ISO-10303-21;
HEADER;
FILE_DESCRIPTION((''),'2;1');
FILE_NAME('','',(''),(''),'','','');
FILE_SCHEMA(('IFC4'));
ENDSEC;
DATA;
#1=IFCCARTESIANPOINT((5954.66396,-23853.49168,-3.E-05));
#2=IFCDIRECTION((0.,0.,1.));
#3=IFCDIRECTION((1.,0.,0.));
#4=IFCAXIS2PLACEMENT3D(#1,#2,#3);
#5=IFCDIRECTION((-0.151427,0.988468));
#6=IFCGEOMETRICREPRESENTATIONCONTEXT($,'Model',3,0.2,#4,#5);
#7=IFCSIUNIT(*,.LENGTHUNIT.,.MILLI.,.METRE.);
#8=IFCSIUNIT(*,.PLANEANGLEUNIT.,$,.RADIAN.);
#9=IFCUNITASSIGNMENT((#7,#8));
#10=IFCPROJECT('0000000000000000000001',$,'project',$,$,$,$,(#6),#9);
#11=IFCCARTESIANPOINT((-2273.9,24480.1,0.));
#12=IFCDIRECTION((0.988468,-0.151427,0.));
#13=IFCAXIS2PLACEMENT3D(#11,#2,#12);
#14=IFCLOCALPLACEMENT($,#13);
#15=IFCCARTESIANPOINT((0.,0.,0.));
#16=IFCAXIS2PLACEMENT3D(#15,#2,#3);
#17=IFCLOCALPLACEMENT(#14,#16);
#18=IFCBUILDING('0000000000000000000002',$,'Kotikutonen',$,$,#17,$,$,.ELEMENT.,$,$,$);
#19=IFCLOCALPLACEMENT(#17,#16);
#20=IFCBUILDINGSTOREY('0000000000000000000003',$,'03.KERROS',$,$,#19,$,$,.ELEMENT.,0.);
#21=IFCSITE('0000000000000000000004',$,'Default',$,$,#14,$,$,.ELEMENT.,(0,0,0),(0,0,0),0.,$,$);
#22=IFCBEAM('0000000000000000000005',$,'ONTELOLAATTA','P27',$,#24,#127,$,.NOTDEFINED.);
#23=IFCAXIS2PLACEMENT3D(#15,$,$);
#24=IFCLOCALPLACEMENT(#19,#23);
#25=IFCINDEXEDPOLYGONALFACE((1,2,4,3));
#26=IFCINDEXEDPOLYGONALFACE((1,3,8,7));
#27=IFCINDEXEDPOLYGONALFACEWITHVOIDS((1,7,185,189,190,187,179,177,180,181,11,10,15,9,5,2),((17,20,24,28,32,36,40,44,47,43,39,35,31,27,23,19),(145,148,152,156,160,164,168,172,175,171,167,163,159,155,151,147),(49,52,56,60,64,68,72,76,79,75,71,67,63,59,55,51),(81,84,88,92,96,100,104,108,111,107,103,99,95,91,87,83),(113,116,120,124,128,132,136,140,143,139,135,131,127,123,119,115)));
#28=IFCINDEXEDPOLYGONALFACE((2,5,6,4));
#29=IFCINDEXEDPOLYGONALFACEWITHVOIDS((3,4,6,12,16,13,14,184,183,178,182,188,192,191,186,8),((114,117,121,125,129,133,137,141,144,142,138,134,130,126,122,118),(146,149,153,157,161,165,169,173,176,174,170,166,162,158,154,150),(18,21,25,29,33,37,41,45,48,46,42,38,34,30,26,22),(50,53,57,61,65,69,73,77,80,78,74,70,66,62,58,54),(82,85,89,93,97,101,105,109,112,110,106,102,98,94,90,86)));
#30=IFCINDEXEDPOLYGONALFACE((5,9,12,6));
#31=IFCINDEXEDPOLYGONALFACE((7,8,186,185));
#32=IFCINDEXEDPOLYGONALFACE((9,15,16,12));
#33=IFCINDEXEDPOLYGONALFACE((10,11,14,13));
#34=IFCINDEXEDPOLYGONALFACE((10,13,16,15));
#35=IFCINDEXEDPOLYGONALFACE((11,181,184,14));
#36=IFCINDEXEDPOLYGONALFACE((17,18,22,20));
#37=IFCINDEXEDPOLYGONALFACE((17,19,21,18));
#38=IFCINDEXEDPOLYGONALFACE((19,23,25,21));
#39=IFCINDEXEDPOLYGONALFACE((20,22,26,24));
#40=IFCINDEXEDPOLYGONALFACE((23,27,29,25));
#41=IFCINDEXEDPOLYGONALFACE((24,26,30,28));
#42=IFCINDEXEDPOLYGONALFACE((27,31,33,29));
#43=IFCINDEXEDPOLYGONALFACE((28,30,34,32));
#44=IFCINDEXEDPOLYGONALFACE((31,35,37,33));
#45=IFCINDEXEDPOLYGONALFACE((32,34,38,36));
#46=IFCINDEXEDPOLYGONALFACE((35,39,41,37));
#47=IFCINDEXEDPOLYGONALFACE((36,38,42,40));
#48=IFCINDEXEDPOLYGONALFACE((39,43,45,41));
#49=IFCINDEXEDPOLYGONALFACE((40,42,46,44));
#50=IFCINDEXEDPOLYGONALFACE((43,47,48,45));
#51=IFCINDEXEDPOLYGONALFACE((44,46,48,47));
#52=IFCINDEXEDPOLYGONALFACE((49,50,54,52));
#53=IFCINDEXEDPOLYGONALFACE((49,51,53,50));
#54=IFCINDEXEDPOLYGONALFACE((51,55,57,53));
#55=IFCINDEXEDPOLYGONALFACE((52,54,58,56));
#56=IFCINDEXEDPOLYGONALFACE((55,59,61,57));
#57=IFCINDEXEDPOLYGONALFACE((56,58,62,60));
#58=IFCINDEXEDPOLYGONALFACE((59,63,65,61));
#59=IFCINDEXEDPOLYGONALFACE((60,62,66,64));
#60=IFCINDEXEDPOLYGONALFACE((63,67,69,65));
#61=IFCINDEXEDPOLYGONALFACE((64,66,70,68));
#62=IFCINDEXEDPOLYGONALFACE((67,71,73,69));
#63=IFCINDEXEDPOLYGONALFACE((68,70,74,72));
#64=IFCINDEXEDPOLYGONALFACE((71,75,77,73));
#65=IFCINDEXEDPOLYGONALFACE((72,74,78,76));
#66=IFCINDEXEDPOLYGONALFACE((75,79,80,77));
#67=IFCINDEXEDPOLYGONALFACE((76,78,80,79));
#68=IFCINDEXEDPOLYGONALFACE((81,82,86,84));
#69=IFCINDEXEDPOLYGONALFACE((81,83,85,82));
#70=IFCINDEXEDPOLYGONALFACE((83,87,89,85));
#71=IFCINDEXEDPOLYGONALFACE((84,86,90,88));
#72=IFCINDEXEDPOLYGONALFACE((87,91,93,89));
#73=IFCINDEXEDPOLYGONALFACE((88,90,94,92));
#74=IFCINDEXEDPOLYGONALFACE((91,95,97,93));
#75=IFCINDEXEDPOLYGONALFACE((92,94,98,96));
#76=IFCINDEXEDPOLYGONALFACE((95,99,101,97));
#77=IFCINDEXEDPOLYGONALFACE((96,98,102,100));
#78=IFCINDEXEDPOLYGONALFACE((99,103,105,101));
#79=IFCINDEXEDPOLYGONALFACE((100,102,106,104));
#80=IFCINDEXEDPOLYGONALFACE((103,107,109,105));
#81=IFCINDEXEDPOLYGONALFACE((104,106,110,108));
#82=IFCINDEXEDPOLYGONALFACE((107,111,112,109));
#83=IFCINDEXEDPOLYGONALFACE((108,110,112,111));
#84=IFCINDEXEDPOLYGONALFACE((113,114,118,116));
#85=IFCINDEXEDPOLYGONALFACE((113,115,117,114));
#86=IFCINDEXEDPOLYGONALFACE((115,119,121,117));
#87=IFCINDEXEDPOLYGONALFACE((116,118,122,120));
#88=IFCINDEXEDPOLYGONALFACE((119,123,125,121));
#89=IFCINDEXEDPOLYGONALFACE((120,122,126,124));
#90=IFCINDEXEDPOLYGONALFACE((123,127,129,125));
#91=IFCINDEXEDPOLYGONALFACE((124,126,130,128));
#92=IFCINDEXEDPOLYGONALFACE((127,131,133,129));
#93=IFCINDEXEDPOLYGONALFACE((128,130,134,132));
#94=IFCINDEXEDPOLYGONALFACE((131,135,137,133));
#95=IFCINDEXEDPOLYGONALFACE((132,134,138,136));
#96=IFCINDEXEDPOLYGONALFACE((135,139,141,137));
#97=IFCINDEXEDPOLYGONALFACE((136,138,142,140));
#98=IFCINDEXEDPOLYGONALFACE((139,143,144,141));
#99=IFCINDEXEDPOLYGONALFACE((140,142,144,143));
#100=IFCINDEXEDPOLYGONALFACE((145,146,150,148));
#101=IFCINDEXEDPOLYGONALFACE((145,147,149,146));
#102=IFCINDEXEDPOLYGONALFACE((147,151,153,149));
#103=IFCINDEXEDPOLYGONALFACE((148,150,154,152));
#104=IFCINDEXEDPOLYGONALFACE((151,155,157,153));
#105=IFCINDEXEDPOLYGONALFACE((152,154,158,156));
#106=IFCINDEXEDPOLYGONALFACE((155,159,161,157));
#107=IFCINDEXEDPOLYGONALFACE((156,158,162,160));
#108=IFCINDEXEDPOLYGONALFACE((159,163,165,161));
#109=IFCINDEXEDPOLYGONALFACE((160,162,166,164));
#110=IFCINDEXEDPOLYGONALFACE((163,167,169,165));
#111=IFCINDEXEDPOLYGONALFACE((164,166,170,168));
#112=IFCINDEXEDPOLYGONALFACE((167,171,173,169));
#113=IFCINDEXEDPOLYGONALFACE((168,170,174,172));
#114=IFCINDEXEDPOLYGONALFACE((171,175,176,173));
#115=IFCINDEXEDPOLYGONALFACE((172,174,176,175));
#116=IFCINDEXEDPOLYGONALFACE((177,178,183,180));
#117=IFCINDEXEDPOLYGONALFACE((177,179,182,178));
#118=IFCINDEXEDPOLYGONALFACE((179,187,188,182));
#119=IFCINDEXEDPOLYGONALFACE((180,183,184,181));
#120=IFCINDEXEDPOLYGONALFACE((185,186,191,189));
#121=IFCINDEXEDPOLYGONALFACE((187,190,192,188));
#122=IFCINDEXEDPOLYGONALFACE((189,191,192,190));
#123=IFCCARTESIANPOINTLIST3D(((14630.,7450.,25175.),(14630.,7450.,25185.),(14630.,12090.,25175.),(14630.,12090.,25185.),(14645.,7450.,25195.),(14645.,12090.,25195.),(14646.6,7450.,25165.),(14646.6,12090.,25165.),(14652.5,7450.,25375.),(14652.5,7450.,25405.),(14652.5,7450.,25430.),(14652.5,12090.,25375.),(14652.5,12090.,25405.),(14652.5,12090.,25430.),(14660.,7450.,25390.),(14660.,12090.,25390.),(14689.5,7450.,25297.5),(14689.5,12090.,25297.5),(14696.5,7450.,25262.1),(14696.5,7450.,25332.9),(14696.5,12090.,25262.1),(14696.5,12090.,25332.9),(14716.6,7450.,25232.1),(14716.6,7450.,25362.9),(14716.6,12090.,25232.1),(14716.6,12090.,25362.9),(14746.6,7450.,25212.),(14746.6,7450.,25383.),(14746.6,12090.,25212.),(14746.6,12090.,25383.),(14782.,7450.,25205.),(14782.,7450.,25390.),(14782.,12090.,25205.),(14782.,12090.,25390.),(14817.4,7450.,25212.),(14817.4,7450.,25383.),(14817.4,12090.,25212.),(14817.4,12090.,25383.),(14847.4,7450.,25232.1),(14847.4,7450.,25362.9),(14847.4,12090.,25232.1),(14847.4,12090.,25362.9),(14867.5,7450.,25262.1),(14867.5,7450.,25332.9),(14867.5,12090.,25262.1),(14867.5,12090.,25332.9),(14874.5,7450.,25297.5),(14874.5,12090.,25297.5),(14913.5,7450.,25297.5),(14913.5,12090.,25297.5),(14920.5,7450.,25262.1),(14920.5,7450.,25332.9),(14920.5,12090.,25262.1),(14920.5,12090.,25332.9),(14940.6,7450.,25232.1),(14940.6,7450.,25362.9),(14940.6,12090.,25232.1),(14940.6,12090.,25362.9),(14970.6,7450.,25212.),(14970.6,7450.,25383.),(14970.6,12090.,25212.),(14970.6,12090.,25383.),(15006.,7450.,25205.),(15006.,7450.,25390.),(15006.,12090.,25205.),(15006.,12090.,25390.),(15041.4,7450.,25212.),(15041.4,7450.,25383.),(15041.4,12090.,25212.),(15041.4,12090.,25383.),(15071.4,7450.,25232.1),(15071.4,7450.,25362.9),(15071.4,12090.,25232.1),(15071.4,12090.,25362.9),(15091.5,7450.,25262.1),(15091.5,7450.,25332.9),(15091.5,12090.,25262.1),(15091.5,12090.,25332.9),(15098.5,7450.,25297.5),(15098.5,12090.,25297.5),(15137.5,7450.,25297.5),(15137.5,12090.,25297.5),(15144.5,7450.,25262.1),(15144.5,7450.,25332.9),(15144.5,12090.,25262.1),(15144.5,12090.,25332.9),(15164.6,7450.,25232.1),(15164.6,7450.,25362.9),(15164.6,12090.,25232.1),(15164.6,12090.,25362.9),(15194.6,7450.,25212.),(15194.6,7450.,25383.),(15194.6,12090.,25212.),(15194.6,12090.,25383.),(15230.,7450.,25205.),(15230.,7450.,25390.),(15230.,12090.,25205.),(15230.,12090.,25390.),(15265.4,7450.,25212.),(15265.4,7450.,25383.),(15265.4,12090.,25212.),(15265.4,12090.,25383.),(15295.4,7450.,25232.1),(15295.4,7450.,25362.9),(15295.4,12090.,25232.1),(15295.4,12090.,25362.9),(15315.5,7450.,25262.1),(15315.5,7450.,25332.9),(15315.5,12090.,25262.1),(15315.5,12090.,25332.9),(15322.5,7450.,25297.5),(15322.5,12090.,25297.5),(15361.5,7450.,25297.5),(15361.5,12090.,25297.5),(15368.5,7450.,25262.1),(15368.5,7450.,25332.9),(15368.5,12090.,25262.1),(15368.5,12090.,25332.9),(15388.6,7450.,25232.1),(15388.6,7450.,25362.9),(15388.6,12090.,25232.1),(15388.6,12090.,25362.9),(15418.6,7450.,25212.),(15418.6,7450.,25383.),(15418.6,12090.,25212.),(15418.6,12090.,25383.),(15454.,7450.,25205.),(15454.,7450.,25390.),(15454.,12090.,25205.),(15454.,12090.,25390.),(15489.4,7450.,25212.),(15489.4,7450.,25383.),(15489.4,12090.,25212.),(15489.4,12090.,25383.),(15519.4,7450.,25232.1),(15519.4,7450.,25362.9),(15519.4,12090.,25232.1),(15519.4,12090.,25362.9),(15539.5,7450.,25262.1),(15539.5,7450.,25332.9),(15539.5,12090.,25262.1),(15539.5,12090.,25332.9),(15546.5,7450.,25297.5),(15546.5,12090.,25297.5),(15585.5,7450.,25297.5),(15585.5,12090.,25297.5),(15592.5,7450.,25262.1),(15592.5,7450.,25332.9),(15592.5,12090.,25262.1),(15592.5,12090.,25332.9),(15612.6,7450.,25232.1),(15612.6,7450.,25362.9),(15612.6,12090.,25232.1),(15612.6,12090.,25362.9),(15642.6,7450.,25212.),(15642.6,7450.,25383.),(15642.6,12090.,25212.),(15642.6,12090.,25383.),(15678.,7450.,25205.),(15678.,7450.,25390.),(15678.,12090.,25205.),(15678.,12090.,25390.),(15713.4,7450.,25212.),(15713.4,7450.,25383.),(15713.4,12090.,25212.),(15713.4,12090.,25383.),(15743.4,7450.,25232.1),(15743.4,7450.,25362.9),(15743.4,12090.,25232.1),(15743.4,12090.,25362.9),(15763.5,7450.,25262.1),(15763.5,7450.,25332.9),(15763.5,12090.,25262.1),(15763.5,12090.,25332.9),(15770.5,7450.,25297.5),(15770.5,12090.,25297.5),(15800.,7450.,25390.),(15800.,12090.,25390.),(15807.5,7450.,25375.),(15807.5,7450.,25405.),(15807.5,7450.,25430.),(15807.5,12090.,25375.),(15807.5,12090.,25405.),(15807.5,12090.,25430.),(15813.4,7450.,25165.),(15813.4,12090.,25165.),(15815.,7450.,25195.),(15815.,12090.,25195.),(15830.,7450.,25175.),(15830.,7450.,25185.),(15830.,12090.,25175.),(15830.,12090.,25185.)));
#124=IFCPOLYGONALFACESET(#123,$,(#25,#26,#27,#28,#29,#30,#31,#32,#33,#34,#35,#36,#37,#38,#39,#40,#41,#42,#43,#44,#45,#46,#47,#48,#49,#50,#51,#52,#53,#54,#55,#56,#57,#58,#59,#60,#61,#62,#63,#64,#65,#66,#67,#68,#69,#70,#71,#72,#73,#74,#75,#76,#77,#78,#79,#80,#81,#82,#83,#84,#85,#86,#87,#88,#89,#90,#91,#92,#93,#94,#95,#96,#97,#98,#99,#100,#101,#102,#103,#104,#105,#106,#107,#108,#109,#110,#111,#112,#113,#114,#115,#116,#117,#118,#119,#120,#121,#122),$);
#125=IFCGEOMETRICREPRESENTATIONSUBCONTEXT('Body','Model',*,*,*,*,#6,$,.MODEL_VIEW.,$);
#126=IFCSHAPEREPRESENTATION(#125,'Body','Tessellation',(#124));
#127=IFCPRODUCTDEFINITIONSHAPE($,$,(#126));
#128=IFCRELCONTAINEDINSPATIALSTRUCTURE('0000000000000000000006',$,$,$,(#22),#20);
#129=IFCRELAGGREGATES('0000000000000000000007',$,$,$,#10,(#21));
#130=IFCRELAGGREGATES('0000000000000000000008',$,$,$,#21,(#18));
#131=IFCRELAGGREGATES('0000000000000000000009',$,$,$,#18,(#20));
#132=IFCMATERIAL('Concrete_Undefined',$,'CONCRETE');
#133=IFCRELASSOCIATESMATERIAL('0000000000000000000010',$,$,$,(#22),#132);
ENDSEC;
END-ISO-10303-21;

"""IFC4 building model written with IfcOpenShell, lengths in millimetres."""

from ifc_helpers import new_model, si_unit, direction, frame, origin_with_axes, place, context, subcontext, project, spatial, line, indexed_curve, outline, extrude, material, element, save


model = new_model("IFC4")

# Units and contexts
model_context = context("Model", 3, precision=0.2, world=frame((5954.66396, -23853.49168, -3e-05), z_axis=(0.0, 0.0, 1.0), x_axis=(1.0, 0.0, 0.0)), true_north=direction((-0.151427, 0.988468)))
body_context = subcontext(model_context, "Body", "Model", "MODEL_VIEW")
ifc_project = project(units=[si_unit("LENGTHUNIT", "METRE", prefix="MILLI"), si_unit("PLANEANGLEUNIT", "RADIAN")], contexts=[model_context])

# Site, building, storey
site_placement = place(None, frame((-2273.9, 24480.1, 0.0), z_axis=(0.0, 0.0, 1.0), x_axis=(0.988468, -0.151427, 0.0)))
site = spatial("IfcSite", under=ifc_project, at=site_placement, Name="Default", CompositionType="ELEMENT", RefLatitude=(0, 0, 0), RefLongitude=(0, 0, 0), RefElevation=0.0)
building_placement = place(site_placement, origin_with_axes())
building = spatial("IfcBuilding", under=site, at=building_placement, Name="Kotikutonen", CompositionType="ELEMENT")
storey_placement = place(building_placement, origin_with_axes())
storey = spatial("IfcBuildingStorey", under=building, at=storey_placement, Name="03.KERROS", CompositionType="ELEMENT", Elevation=0.0)

# Shared definitions
ifc_material_1 = material(Name="Concrete_Undefined", Category="CONCRETE")

# Beam
beam_1_placement = place(storey_placement, frame((15230.0, 12090.0, 25297.5), z_axis=(-1.0, 0.0, 0.0), x_axis=(0.0, -1.0, 0.0)))
element("IfcBeam", 1, at=beam_1_placement, inside=storey, material=ifc_material_1, Name="ONTELOLAATTA", Description="P27", PredefinedType="NOTDEFINED", context=body_context, shape_type="SolidModel", body=[
    extrude(outline(indexed_curve([(-600.0, -122.5), (-583.4, -132.5), (583.4, -132.5), (600.0, -122.5), (600.0, -112.5), (585.0, -102.5), (577.5, 77.5), (570.0, 92.5), (577.5, 107.5), (577.5, 132.5), (-577.5, 132.5), (-577.5, 107.5), (-570.0, 92.5), (-577.5, 77.5), (-585.0, -102.5), (-600.0, -112.5)], segments=[line(1, 2, 3, 4, 5, 6, 7, 8, 9, 10, 11, 12, 13, 14, 15, 16, 1)]), holes=[indexed_curve([(-448.0, -92.5), (-483.4, -85.5), (-513.4, -65.4), (-533.5, -35.4), (-540.5, 0.0), (-533.5, 35.4), (-513.4, 65.4), (-483.4, 85.5), (-448.0, 92.5), (-412.6, 85.5), (-382.6, 65.4), (-362.5, 35.4), (-355.5, 0.0), (-362.5, -35.4), (-382.6, -65.4), (-412.6, -85.5)], segments=[line(1, 2, 3, 4, 5, 6, 7, 8, 9, 10, 11, 12, 13, 14, 15, 16, 1)]), indexed_curve([(-224.0, -92.5), (-259.4, -85.5), (-289.4, -65.4), (-309.5, -35.4), (-316.5, 0.0), (-309.5, 35.4), (-289.4, 65.4), (-259.4, 85.5), (-224.0, 92.5), (-188.6, 85.5), (-158.6, 65.4), (-138.5, 35.4), (-131.5, 0.0), (-138.5, -35.4), (-158.6, -65.4), (-188.6, -85.5)], segments=[line(1, 2, 3, 4, 5, 6, 7, 8, 9, 10, 11, 12, 13, 14, 15, 16, 1)]), indexed_curve([(0.0, -92.5), (-35.4, -85.5), (-65.4, -65.4), (-85.5, -35.4), (-92.5, 0.0), (-85.5, 35.4), (-65.4, 65.4), (-35.4, 85.5), (0.0, 92.5), (35.4, 85.5), (65.4, 65.4), (85.5, 35.4), (92.5, 0.0), (85.5, -35.4), (65.4, -65.4), (35.4, -85.5)], segments=[line(1, 2, 3, 4, 5, 6, 7, 8, 9, 10, 11, 12, 13, 14, 15, 16, 1)]), indexed_curve([(224.0, -92.5), (188.6, -85.5), (158.6, -65.4), (138.5, -35.4), (131.5, 0.0), (138.5, 35.4), (158.6, 65.4), (188.6, 85.5), (224.0, 92.5), (259.4, 85.5), (289.4, 65.4), (309.5, 35.4), (316.5, 0.0), (309.5, -35.4), (289.4, -65.4), (259.4, -85.5)], segments=[line(1, 2, 3, 4, 5, 6, 7, 8, 9, 10, 11, 12, 13, 14, 15, 16, 1)]), indexed_curve([(448.0, -92.5), (412.6, -85.5), (382.6, -65.4), (362.5, -35.4), (355.5, 0.0), (362.5, 35.4), (382.6, 65.4), (412.6, 85.5), (448.0, 92.5), (483.4, 85.5), (513.4, 65.4), (533.5, 35.4), (540.5, 0.0), (533.5, -35.4), (513.4, -65.4), (483.4, -85.5)], segments=[line(1, 2, 3, 4, 5, 6, 7, 8, 9, 10, 11, 12, 13, 14, 15, 16, 1)])]), frame((0.0, 0.0, 0.0), z_axis=(-1.0, 0.0, 0.0), x_axis=(0.0, 0.0, 1.0)), (0.0, 0.0, -1.0), 4640.0),
])

save(model, "model.ifc")
